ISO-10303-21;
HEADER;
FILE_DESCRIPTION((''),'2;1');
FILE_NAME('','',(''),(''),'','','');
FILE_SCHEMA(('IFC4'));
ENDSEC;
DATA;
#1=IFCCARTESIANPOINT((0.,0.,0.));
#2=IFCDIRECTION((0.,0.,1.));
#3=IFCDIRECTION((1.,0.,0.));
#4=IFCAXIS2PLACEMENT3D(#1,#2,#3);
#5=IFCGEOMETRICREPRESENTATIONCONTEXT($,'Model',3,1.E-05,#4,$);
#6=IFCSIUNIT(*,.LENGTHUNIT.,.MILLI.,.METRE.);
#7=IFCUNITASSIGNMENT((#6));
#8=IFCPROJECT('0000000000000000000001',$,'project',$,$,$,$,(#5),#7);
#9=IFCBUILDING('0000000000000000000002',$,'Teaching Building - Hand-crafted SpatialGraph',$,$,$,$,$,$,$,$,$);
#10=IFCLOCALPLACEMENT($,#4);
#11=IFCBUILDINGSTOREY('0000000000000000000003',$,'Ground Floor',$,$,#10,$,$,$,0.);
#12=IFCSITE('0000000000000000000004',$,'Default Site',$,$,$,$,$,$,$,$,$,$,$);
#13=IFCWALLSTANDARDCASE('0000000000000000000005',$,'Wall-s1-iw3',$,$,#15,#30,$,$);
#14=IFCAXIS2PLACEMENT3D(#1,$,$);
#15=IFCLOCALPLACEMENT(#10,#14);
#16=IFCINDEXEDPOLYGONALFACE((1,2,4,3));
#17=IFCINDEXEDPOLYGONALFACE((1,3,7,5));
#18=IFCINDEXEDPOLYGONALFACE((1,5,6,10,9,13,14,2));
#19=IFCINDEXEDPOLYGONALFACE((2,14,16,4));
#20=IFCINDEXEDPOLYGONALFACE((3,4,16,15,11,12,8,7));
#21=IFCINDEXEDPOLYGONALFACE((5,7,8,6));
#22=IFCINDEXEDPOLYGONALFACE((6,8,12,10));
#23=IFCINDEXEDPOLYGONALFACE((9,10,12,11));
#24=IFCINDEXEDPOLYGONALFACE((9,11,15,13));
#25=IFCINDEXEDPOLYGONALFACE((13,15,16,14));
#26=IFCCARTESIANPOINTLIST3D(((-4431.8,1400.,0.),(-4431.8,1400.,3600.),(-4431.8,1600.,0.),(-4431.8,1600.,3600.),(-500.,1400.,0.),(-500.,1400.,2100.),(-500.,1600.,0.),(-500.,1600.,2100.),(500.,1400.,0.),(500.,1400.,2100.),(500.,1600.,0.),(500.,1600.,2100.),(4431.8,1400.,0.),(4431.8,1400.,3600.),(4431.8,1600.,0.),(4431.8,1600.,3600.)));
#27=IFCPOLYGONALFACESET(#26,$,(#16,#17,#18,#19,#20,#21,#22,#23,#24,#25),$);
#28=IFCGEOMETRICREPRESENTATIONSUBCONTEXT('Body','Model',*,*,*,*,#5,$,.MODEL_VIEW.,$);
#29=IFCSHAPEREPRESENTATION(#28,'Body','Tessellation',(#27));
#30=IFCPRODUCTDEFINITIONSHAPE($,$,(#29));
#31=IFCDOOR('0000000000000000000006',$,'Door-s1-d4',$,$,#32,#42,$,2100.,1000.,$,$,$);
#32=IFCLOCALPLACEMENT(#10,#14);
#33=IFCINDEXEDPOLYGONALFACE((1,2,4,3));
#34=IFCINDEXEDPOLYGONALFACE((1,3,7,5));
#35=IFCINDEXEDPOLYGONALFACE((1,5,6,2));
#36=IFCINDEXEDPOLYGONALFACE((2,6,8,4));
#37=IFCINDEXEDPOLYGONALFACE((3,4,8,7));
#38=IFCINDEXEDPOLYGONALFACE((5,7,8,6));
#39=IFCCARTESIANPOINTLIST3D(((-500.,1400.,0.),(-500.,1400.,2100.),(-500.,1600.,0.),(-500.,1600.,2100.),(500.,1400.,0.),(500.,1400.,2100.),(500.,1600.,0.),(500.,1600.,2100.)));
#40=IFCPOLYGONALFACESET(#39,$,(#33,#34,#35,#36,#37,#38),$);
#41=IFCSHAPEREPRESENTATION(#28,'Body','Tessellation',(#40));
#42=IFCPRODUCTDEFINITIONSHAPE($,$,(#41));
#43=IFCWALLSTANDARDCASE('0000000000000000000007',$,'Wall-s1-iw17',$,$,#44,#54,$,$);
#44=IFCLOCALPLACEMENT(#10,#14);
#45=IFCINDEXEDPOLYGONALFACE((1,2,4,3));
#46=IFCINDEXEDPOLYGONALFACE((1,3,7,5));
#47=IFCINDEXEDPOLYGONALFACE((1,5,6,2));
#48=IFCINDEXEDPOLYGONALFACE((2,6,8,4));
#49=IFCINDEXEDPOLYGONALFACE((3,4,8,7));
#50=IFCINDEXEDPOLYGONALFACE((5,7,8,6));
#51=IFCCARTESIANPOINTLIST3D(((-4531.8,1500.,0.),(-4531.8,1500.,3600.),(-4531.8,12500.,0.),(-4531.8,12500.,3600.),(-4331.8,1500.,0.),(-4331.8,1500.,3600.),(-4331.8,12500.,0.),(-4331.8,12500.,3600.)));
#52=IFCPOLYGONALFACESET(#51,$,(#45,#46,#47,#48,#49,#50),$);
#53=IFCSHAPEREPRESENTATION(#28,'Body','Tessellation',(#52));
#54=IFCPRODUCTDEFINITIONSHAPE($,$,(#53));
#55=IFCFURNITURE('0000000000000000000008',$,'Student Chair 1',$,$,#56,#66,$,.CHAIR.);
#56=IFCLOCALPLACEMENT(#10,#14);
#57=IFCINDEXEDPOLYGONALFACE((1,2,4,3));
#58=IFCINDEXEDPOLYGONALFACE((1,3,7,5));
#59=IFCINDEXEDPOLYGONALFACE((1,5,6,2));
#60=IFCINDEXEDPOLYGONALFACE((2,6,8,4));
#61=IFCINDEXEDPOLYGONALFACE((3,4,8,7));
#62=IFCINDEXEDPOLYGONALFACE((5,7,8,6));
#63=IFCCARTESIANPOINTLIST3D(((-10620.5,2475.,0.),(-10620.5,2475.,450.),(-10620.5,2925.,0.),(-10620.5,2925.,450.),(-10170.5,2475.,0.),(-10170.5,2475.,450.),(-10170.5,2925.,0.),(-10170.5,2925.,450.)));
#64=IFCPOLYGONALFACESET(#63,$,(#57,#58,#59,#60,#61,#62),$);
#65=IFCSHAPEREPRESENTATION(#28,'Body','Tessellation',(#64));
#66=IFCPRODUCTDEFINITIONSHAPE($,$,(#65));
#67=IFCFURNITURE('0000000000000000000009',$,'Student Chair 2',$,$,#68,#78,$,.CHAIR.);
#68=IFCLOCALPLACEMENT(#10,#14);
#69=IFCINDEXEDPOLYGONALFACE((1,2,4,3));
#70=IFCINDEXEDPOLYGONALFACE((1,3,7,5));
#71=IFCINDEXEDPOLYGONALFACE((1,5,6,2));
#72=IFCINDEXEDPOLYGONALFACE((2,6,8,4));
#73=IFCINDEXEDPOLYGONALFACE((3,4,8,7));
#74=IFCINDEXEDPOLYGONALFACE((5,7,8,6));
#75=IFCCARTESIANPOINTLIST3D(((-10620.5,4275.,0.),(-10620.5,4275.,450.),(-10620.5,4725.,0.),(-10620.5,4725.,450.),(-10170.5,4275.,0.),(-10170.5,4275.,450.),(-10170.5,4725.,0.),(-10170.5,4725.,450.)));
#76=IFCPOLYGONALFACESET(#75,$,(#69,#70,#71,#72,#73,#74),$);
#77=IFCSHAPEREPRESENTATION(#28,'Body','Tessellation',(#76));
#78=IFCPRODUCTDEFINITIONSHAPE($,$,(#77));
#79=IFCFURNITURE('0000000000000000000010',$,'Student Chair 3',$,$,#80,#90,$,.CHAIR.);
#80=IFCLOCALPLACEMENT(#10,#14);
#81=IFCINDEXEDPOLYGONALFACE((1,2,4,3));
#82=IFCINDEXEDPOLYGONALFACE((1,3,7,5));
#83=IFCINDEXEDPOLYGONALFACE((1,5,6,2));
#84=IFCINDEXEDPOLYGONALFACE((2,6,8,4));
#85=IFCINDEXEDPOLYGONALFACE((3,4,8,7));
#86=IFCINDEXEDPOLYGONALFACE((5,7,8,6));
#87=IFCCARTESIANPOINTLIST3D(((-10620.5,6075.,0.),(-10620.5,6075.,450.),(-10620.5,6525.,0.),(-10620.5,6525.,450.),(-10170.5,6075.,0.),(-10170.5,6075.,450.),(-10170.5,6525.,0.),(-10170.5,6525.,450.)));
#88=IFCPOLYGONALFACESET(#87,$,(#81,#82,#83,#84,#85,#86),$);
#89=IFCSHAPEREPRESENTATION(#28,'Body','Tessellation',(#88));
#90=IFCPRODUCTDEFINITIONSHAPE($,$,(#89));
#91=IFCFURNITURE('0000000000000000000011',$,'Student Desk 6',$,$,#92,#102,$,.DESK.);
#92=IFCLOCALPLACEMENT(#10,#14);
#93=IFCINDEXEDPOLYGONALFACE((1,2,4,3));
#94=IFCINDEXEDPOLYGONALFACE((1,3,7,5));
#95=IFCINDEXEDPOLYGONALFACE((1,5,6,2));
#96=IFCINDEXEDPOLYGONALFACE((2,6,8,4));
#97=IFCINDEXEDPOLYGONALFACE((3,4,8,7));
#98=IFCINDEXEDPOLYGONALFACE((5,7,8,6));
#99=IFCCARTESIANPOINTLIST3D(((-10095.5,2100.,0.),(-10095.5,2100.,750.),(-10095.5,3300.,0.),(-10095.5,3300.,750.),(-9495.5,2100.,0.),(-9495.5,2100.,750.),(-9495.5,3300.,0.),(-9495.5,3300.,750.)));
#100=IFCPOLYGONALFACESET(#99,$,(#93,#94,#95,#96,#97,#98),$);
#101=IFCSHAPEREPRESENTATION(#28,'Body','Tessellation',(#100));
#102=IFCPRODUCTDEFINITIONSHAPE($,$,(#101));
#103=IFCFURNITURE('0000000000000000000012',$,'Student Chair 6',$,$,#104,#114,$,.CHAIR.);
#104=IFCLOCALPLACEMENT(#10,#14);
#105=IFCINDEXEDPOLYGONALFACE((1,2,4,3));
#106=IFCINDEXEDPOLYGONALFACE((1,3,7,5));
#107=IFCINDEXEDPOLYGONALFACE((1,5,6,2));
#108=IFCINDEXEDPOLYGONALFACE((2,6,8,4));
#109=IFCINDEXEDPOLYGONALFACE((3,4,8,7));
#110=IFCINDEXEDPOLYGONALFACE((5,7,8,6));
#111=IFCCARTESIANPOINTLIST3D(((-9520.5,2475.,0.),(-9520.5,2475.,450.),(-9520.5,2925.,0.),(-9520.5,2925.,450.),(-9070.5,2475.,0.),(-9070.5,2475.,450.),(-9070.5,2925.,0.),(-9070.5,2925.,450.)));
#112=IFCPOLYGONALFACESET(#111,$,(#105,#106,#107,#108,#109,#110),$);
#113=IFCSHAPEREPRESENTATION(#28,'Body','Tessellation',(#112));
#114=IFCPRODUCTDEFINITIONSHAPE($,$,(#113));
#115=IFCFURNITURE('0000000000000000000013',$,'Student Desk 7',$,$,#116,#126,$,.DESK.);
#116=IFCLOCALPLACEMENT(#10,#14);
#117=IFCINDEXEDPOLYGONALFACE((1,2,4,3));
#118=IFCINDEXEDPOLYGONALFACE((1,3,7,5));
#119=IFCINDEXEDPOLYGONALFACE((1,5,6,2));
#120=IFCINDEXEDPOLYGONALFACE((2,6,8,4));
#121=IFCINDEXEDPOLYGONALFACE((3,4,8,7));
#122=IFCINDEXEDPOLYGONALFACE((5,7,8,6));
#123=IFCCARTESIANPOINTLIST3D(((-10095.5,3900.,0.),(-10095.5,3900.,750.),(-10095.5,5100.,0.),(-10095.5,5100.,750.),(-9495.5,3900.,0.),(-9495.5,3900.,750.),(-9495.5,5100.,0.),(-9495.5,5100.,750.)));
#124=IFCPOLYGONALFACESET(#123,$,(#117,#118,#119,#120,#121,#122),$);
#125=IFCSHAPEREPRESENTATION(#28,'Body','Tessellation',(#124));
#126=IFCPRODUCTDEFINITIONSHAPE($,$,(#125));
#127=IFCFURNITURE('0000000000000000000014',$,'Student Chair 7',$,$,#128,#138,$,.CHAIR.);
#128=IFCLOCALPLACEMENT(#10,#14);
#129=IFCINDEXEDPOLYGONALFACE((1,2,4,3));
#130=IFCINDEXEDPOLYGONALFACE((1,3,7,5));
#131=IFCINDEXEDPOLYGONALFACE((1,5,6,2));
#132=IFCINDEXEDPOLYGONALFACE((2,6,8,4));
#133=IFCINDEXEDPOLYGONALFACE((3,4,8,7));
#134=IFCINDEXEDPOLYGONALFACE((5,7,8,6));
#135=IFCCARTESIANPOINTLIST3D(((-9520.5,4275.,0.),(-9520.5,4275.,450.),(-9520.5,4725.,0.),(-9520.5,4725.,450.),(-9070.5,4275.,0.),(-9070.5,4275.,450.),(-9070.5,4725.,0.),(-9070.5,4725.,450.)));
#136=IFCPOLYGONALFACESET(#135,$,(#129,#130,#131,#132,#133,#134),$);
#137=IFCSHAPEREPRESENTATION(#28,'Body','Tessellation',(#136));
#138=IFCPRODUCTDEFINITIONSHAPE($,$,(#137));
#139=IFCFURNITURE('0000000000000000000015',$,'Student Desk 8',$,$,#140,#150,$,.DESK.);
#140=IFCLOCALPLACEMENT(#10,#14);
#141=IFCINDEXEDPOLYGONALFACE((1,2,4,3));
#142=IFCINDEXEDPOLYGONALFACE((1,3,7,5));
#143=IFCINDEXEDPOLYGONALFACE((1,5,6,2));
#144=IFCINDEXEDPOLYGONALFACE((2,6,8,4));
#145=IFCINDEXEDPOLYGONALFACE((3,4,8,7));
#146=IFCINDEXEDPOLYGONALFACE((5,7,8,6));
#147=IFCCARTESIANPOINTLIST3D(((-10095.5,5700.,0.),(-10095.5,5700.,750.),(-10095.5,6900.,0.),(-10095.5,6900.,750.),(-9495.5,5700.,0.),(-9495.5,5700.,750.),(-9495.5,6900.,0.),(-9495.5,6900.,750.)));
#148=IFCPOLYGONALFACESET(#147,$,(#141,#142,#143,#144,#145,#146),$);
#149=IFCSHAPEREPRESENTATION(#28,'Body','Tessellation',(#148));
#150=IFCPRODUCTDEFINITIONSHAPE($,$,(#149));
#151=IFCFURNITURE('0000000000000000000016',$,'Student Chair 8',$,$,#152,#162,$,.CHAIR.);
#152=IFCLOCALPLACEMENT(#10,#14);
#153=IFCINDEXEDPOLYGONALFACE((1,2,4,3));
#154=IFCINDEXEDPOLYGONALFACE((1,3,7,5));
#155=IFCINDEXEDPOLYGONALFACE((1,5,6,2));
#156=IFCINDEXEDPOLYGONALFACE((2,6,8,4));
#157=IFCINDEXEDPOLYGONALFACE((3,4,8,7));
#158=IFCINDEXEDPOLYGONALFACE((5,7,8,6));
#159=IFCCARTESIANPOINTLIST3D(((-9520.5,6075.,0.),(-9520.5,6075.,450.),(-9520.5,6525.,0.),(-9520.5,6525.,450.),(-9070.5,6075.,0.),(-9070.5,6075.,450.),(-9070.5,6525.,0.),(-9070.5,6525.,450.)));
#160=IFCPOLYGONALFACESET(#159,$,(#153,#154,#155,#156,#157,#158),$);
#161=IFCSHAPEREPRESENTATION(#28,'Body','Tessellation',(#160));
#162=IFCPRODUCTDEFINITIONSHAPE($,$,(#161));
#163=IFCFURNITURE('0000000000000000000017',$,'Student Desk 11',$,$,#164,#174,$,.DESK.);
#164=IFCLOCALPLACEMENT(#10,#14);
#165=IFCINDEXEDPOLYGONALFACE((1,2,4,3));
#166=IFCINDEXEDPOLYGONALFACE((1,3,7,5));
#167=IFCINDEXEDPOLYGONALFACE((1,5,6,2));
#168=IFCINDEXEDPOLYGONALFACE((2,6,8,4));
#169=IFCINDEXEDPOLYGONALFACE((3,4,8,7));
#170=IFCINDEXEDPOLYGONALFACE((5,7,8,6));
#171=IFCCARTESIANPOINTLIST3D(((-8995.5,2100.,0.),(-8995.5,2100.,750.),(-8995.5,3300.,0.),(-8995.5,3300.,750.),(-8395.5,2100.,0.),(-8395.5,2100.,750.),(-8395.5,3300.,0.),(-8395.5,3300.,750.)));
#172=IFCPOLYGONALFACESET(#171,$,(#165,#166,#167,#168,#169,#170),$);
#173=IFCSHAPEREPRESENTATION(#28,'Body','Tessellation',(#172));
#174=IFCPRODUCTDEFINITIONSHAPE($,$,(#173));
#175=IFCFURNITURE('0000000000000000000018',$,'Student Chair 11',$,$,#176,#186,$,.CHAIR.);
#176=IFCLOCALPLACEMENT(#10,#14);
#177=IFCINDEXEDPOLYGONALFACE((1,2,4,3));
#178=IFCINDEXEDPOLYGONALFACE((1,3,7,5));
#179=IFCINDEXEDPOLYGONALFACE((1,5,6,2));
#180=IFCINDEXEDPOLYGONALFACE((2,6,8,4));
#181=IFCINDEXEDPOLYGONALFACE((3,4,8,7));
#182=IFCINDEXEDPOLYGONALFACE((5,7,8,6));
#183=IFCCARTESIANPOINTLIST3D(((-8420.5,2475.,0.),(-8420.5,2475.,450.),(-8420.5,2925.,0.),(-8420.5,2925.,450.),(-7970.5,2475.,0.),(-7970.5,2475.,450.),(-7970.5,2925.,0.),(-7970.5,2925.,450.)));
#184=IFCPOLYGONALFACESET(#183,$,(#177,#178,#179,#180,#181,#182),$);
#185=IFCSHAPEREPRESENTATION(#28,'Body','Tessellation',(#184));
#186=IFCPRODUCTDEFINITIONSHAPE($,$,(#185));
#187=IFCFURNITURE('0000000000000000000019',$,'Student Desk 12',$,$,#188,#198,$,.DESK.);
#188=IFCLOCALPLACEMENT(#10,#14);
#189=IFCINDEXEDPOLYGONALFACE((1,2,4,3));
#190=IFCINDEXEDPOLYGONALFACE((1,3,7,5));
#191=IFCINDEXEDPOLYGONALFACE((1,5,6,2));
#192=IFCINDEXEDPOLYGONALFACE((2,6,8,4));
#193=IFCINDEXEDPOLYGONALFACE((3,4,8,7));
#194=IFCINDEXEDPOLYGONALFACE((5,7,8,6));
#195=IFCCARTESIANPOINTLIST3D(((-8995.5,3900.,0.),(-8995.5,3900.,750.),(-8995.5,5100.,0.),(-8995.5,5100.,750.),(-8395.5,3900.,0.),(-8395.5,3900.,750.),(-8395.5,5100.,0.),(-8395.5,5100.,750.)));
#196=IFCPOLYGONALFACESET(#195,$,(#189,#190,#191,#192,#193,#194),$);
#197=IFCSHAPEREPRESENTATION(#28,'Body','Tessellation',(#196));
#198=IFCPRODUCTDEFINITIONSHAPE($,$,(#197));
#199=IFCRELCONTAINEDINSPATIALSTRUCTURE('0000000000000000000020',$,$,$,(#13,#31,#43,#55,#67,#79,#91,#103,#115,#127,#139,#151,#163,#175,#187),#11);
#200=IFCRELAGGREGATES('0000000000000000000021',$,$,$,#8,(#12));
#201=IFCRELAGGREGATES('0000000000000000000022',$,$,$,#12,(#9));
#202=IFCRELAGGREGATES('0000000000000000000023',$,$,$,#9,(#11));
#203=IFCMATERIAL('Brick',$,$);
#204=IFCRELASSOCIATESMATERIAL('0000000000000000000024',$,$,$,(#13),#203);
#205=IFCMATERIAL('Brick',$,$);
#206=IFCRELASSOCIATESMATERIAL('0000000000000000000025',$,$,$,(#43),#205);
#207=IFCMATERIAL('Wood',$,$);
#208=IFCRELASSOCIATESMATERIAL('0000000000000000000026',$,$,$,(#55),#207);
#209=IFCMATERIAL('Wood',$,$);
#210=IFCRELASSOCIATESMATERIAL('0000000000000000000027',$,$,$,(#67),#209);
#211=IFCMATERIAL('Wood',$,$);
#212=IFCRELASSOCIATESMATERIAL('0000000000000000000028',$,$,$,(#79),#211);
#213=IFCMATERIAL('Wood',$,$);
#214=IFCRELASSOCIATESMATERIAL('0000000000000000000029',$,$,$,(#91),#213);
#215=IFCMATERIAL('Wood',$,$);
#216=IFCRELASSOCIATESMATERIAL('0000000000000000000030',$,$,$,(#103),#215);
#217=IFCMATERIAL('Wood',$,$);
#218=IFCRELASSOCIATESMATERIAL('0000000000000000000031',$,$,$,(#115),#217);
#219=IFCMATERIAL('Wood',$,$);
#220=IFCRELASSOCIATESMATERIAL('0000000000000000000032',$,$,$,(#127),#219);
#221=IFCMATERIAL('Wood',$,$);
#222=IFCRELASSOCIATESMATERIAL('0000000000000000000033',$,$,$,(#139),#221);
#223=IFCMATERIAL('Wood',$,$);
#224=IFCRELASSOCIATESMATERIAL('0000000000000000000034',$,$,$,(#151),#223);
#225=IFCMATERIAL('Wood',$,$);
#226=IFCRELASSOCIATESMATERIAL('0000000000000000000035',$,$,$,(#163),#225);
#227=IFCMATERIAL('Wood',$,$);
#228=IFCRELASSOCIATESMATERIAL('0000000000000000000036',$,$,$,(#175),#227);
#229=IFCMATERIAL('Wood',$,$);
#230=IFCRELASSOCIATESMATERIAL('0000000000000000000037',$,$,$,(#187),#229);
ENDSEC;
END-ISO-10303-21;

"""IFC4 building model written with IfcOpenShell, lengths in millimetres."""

from ifc_helpers import new_model, si_unit, frame, frame_2d, origin_with_axes, origin_2d, place, context, subcontext, project, spatial, rectangle, extrude, material, element, fill, save


model = new_model("IFC4")

# Units and contexts
model_context = context("Model", 3, precision=1e-05, world=origin_with_axes())
body_context = subcontext(model_context, "Body", "Model", "MODEL_VIEW")
ifc_project = project(units=[si_unit("LENGTHUNIT", "METRE", prefix="MILLI")], contexts=[model_context])

# Site, building, storey
site = spatial("IfcSite", under=ifc_project, Name="Default Site")
building = spatial("IfcBuilding", under=site, Name="Teaching Building - Hand-crafted SpatialGraph")
storey_placement = place(None, origin_with_axes())
storey = spatial("IfcBuildingStorey", under=building, at=storey_placement, Name="Ground Floor", Elevation=0.0)

# Wall, opening, door
ifc_material_1 = material(Name="Brick")
wall_1_placement = place(storey_placement, frame((-4431.8, 1500.0, 0.0), z_axis=(0.0, 0.0, 1.0), x_axis=(1.0, 0.0, 0.0)))
wall_1 = element("IfcWallStandardCase", 1, at=wall_1_placement, inside=storey, material=ifc_material_1, Name="Wall-s1-iw3", context=body_context, shape_type="SweptSolid", body=[
    extrude(rectangle(XDim=8863.6, YDim=200.0, at=frame_2d((4431.8, 0.0))), origin_with_axes(), (0.0, 0.0, 1.0), 3600.0),
])
opening_placement = place(wall_1_placement, frame((3931.8, 0.0, 0.0), z_axis=(0.0, 0.0, 1.0), x_axis=(1.0, 0.0, 0.0)))
opening = element("IfcOpeningElement", 2, at=opening_placement, cuts=wall_1, context=body_context, shape_type="SweptSolid", body=[
    extrude(rectangle(XDim=1000.0, YDim=400.0, at=frame_2d((500.0, 0.0))), origin_with_axes(), (0.0, 0.0, 1.0), 2100.0),
])
door_placement = place(storey_placement, frame((-500.0, 1500.0, 0.0), z_axis=(0.0, 0.0, 1.0), x_axis=(1.0, 0.0, 0.0)))
door = element("IfcDoor", 3, at=door_placement, inside=storey, Name="Door-s1-d4", OverallHeight=2100.0, OverallWidth=1000.0, context=body_context, shape_type="SweptSolid", body=[
    extrude(rectangle(XDim=1000.0, YDim=200.0, at=frame_2d((500.0, 0.0))), origin_with_axes(), (0.0, 0.0, 1.0), 2100.0),
])
fill(opening, door)

# Wall
ifc_material_2 = material(Name="Brick")
wall_2_placement = place(storey_placement, frame((-4431.8, 1500.0, 0.0), z_axis=(0.0, 0.0, 1.0), x_axis=(0.0, 1.0, 0.0)))
element("IfcWallStandardCase", 4, at=wall_2_placement, inside=storey, material=ifc_material_2, Name="Wall-s1-iw17", context=body_context, shape_type="SweptSolid", body=[
    extrude(rectangle(XDim=11000.0, YDim=200.0, at=frame_2d((5500.0, 0.0))), origin_with_axes(), (0.0, 0.0, 1.0), 3600.0),
])

# Furniture
ifc_material_3 = material(Name="Wood")
furniture_1_placement = place(storey_placement, frame((-10395.5, 2700.0, 0.0), z_axis=(0.0, 0.0, 1.0), x_axis=(1.0, 0.0, 0.0)))
element("IfcFurniture", 5, at=furniture_1_placement, inside=storey, material=ifc_material_3, Name="Student Chair 1", PredefinedType="CHAIR", context=body_context, shape_type="SweptSolid", body=[
    extrude(rectangle(XDim=450.0, YDim=450.0, at=origin_2d()), origin_with_axes(), (0.0, 0.0, 1.0), 450.0),
])
ifc_material_4 = material(Name="Wood")
furniture_2_placement = place(storey_placement, frame((-10395.5, 4500.0, 0.0), z_axis=(0.0, 0.0, 1.0), x_axis=(1.0, 0.0, 0.0)))
element("IfcFurniture", 6, at=furniture_2_placement, inside=storey, material=ifc_material_4, Name="Student Chair 2", PredefinedType="CHAIR", context=body_context, shape_type="SweptSolid", body=[
    extrude(rectangle(XDim=450.0, YDim=450.0, at=origin_2d()), origin_with_axes(), (0.0, 0.0, 1.0), 450.0),
])
ifc_material_5 = material(Name="Wood")
furniture_3_placement = place(storey_placement, frame((-10395.5, 6300.0, 0.0), z_axis=(0.0, 0.0, 1.0), x_axis=(1.0, 0.0, 0.0)))
element("IfcFurniture", 7, at=furniture_3_placement, inside=storey, material=ifc_material_5, Name="Student Chair 3", PredefinedType="CHAIR", context=body_context, shape_type="SweptSolid", body=[
    extrude(rectangle(XDim=450.0, YDim=450.0, at=origin_2d()), origin_with_axes(), (0.0, 0.0, 1.0), 450.0),
])
ifc_material_6 = material(Name="Wood")
furniture_4_placement = place(storey_placement, frame((-9795.5, 2700.0, 0.0), z_axis=(0.0, 0.0, 1.0), x_axis=(0.0, 1.0, 0.0)))
element("IfcFurniture", 8, at=furniture_4_placement, inside=storey, material=ifc_material_6, Name="Student Desk 6", PredefinedType="DESK", context=body_context, shape_type="SweptSolid", body=[
    extrude(rectangle(XDim=1200.0, YDim=600.0, at=origin_2d()), origin_with_axes(), (0.0, 0.0, 1.0), 750.0),
])
ifc_material_7 = material(Name="Wood")
furniture_5_placement = place(storey_placement, frame((-9295.5, 2700.0, 0.0), z_axis=(0.0, 0.0, 1.0), x_axis=(1.0, 0.0, 0.0)))
element("IfcFurniture", 9, at=furniture_5_placement, inside=storey, material=ifc_material_7, Name="Student Chair 6", PredefinedType="CHAIR", context=body_context, shape_type="SweptSolid", body=[
    extrude(rectangle(XDim=450.0, YDim=450.0, at=origin_2d()), origin_with_axes(), (0.0, 0.0, 1.0), 450.0),
])
ifc_material_8 = material(Name="Wood")
furniture_6_placement = place(storey_placement, frame((-9795.5, 4500.0, 0.0), z_axis=(0.0, 0.0, 1.0), x_axis=(0.0, 1.0, 0.0)))
element("IfcFurniture", 10, at=furniture_6_placement, inside=storey, material=ifc_material_8, Name="Student Desk 7", PredefinedType="DESK", context=body_context, shape_type="SweptSolid", body=[
    extrude(rectangle(XDim=1200.0, YDim=600.0, at=origin_2d()), origin_with_axes(), (0.0, 0.0, 1.0), 750.0),
])
ifc_material_9 = material(Name="Wood")
furniture_7_placement = place(storey_placement, frame((-9295.5, 4500.0, 0.0), z_axis=(0.0, 0.0, 1.0), x_axis=(1.0, 0.0, 0.0)))
element("IfcFurniture", 11, at=furniture_7_placement, inside=storey, material=ifc_material_9, Name="Student Chair 7", PredefinedType="CHAIR", context=body_context, shape_type="SweptSolid", body=[
    extrude(rectangle(XDim=450.0, YDim=450.0, at=origin_2d()), origin_with_axes(), (0.0, 0.0, 1.0), 450.0),
])
ifc_material_10 = material(Name="Wood")
furniture_8_placement = place(storey_placement, frame((-9795.5, 6300.0, 0.0), z_axis=(0.0, 0.0, 1.0), x_axis=(0.0, 1.0, 0.0)))
element("IfcFurniture", 12, at=furniture_8_placement, inside=storey, material=ifc_material_10, Name="Student Desk 8", PredefinedType="DESK", context=body_context, shape_type="SweptSolid", body=[
    extrude(rectangle(XDim=1200.0, YDim=600.0, at=origin_2d()), origin_with_axes(), (0.0, 0.0, 1.0), 750.0),
])
ifc_material_11 = material(Name="Wood")
furniture_9_placement = place(storey_placement, frame((-9295.5, 6300.0, 0.0), z_axis=(0.0, 0.0, 1.0), x_axis=(1.0, 0.0, 0.0)))
element("IfcFurniture", 13, at=furniture_9_placement, inside=storey, material=ifc_material_11, Name="Student Chair 8", PredefinedType="CHAIR", context=body_context, shape_type="SweptSolid", body=[
    extrude(rectangle(XDim=450.0, YDim=450.0, at=origin_2d()), origin_with_axes(), (0.0, 0.0, 1.0), 450.0),
])
ifc_material_12 = material(Name="Wood")
furniture_10_placement = place(storey_placement, frame((-8695.5, 2700.0, 0.0), z_axis=(0.0, 0.0, 1.0), x_axis=(0.0, 1.0, 0.0)))
element("IfcFurniture", 14, at=furniture_10_placement, inside=storey, material=ifc_material_12, Name="Student Desk 11", PredefinedType="DESK", context=body_context, shape_type="SweptSolid", body=[
    extrude(rectangle(XDim=1200.0, YDim=600.0, at=origin_2d()), origin_with_axes(), (0.0, 0.0, 1.0), 750.0),
])
ifc_material_13 = material(Name="Wood")
furniture_11_placement = place(storey_placement, frame((-8195.5, 2700.0, 0.0), z_axis=(0.0, 0.0, 1.0), x_axis=(1.0, 0.0, 0.0)))
element("IfcFurniture", 15, at=furniture_11_placement, inside=storey, material=ifc_material_13, Name="Student Chair 11", PredefinedType="CHAIR", context=body_context, shape_type="SweptSolid", body=[
    extrude(rectangle(XDim=450.0, YDim=450.0, at=origin_2d()), origin_with_axes(), (0.0, 0.0, 1.0), 450.0),
])
ifc_material_14 = material(Name="Wood")
furniture_12_placement = place(storey_placement, frame((-8695.5, 4500.0, 0.0), z_axis=(0.0, 0.0, 1.0), x_axis=(0.0, 1.0, 0.0)))
element("IfcFurniture", 16, at=furniture_12_placement, inside=storey, material=ifc_material_14, Name="Student Desk 12", PredefinedType="DESK", context=body_context, shape_type="SweptSolid", body=[
    extrude(rectangle(XDim=1200.0, YDim=600.0, at=origin_2d()), origin_with_axes(), (0.0, 0.0, 1.0), 750.0),
])

save(model, "model.ifc")
